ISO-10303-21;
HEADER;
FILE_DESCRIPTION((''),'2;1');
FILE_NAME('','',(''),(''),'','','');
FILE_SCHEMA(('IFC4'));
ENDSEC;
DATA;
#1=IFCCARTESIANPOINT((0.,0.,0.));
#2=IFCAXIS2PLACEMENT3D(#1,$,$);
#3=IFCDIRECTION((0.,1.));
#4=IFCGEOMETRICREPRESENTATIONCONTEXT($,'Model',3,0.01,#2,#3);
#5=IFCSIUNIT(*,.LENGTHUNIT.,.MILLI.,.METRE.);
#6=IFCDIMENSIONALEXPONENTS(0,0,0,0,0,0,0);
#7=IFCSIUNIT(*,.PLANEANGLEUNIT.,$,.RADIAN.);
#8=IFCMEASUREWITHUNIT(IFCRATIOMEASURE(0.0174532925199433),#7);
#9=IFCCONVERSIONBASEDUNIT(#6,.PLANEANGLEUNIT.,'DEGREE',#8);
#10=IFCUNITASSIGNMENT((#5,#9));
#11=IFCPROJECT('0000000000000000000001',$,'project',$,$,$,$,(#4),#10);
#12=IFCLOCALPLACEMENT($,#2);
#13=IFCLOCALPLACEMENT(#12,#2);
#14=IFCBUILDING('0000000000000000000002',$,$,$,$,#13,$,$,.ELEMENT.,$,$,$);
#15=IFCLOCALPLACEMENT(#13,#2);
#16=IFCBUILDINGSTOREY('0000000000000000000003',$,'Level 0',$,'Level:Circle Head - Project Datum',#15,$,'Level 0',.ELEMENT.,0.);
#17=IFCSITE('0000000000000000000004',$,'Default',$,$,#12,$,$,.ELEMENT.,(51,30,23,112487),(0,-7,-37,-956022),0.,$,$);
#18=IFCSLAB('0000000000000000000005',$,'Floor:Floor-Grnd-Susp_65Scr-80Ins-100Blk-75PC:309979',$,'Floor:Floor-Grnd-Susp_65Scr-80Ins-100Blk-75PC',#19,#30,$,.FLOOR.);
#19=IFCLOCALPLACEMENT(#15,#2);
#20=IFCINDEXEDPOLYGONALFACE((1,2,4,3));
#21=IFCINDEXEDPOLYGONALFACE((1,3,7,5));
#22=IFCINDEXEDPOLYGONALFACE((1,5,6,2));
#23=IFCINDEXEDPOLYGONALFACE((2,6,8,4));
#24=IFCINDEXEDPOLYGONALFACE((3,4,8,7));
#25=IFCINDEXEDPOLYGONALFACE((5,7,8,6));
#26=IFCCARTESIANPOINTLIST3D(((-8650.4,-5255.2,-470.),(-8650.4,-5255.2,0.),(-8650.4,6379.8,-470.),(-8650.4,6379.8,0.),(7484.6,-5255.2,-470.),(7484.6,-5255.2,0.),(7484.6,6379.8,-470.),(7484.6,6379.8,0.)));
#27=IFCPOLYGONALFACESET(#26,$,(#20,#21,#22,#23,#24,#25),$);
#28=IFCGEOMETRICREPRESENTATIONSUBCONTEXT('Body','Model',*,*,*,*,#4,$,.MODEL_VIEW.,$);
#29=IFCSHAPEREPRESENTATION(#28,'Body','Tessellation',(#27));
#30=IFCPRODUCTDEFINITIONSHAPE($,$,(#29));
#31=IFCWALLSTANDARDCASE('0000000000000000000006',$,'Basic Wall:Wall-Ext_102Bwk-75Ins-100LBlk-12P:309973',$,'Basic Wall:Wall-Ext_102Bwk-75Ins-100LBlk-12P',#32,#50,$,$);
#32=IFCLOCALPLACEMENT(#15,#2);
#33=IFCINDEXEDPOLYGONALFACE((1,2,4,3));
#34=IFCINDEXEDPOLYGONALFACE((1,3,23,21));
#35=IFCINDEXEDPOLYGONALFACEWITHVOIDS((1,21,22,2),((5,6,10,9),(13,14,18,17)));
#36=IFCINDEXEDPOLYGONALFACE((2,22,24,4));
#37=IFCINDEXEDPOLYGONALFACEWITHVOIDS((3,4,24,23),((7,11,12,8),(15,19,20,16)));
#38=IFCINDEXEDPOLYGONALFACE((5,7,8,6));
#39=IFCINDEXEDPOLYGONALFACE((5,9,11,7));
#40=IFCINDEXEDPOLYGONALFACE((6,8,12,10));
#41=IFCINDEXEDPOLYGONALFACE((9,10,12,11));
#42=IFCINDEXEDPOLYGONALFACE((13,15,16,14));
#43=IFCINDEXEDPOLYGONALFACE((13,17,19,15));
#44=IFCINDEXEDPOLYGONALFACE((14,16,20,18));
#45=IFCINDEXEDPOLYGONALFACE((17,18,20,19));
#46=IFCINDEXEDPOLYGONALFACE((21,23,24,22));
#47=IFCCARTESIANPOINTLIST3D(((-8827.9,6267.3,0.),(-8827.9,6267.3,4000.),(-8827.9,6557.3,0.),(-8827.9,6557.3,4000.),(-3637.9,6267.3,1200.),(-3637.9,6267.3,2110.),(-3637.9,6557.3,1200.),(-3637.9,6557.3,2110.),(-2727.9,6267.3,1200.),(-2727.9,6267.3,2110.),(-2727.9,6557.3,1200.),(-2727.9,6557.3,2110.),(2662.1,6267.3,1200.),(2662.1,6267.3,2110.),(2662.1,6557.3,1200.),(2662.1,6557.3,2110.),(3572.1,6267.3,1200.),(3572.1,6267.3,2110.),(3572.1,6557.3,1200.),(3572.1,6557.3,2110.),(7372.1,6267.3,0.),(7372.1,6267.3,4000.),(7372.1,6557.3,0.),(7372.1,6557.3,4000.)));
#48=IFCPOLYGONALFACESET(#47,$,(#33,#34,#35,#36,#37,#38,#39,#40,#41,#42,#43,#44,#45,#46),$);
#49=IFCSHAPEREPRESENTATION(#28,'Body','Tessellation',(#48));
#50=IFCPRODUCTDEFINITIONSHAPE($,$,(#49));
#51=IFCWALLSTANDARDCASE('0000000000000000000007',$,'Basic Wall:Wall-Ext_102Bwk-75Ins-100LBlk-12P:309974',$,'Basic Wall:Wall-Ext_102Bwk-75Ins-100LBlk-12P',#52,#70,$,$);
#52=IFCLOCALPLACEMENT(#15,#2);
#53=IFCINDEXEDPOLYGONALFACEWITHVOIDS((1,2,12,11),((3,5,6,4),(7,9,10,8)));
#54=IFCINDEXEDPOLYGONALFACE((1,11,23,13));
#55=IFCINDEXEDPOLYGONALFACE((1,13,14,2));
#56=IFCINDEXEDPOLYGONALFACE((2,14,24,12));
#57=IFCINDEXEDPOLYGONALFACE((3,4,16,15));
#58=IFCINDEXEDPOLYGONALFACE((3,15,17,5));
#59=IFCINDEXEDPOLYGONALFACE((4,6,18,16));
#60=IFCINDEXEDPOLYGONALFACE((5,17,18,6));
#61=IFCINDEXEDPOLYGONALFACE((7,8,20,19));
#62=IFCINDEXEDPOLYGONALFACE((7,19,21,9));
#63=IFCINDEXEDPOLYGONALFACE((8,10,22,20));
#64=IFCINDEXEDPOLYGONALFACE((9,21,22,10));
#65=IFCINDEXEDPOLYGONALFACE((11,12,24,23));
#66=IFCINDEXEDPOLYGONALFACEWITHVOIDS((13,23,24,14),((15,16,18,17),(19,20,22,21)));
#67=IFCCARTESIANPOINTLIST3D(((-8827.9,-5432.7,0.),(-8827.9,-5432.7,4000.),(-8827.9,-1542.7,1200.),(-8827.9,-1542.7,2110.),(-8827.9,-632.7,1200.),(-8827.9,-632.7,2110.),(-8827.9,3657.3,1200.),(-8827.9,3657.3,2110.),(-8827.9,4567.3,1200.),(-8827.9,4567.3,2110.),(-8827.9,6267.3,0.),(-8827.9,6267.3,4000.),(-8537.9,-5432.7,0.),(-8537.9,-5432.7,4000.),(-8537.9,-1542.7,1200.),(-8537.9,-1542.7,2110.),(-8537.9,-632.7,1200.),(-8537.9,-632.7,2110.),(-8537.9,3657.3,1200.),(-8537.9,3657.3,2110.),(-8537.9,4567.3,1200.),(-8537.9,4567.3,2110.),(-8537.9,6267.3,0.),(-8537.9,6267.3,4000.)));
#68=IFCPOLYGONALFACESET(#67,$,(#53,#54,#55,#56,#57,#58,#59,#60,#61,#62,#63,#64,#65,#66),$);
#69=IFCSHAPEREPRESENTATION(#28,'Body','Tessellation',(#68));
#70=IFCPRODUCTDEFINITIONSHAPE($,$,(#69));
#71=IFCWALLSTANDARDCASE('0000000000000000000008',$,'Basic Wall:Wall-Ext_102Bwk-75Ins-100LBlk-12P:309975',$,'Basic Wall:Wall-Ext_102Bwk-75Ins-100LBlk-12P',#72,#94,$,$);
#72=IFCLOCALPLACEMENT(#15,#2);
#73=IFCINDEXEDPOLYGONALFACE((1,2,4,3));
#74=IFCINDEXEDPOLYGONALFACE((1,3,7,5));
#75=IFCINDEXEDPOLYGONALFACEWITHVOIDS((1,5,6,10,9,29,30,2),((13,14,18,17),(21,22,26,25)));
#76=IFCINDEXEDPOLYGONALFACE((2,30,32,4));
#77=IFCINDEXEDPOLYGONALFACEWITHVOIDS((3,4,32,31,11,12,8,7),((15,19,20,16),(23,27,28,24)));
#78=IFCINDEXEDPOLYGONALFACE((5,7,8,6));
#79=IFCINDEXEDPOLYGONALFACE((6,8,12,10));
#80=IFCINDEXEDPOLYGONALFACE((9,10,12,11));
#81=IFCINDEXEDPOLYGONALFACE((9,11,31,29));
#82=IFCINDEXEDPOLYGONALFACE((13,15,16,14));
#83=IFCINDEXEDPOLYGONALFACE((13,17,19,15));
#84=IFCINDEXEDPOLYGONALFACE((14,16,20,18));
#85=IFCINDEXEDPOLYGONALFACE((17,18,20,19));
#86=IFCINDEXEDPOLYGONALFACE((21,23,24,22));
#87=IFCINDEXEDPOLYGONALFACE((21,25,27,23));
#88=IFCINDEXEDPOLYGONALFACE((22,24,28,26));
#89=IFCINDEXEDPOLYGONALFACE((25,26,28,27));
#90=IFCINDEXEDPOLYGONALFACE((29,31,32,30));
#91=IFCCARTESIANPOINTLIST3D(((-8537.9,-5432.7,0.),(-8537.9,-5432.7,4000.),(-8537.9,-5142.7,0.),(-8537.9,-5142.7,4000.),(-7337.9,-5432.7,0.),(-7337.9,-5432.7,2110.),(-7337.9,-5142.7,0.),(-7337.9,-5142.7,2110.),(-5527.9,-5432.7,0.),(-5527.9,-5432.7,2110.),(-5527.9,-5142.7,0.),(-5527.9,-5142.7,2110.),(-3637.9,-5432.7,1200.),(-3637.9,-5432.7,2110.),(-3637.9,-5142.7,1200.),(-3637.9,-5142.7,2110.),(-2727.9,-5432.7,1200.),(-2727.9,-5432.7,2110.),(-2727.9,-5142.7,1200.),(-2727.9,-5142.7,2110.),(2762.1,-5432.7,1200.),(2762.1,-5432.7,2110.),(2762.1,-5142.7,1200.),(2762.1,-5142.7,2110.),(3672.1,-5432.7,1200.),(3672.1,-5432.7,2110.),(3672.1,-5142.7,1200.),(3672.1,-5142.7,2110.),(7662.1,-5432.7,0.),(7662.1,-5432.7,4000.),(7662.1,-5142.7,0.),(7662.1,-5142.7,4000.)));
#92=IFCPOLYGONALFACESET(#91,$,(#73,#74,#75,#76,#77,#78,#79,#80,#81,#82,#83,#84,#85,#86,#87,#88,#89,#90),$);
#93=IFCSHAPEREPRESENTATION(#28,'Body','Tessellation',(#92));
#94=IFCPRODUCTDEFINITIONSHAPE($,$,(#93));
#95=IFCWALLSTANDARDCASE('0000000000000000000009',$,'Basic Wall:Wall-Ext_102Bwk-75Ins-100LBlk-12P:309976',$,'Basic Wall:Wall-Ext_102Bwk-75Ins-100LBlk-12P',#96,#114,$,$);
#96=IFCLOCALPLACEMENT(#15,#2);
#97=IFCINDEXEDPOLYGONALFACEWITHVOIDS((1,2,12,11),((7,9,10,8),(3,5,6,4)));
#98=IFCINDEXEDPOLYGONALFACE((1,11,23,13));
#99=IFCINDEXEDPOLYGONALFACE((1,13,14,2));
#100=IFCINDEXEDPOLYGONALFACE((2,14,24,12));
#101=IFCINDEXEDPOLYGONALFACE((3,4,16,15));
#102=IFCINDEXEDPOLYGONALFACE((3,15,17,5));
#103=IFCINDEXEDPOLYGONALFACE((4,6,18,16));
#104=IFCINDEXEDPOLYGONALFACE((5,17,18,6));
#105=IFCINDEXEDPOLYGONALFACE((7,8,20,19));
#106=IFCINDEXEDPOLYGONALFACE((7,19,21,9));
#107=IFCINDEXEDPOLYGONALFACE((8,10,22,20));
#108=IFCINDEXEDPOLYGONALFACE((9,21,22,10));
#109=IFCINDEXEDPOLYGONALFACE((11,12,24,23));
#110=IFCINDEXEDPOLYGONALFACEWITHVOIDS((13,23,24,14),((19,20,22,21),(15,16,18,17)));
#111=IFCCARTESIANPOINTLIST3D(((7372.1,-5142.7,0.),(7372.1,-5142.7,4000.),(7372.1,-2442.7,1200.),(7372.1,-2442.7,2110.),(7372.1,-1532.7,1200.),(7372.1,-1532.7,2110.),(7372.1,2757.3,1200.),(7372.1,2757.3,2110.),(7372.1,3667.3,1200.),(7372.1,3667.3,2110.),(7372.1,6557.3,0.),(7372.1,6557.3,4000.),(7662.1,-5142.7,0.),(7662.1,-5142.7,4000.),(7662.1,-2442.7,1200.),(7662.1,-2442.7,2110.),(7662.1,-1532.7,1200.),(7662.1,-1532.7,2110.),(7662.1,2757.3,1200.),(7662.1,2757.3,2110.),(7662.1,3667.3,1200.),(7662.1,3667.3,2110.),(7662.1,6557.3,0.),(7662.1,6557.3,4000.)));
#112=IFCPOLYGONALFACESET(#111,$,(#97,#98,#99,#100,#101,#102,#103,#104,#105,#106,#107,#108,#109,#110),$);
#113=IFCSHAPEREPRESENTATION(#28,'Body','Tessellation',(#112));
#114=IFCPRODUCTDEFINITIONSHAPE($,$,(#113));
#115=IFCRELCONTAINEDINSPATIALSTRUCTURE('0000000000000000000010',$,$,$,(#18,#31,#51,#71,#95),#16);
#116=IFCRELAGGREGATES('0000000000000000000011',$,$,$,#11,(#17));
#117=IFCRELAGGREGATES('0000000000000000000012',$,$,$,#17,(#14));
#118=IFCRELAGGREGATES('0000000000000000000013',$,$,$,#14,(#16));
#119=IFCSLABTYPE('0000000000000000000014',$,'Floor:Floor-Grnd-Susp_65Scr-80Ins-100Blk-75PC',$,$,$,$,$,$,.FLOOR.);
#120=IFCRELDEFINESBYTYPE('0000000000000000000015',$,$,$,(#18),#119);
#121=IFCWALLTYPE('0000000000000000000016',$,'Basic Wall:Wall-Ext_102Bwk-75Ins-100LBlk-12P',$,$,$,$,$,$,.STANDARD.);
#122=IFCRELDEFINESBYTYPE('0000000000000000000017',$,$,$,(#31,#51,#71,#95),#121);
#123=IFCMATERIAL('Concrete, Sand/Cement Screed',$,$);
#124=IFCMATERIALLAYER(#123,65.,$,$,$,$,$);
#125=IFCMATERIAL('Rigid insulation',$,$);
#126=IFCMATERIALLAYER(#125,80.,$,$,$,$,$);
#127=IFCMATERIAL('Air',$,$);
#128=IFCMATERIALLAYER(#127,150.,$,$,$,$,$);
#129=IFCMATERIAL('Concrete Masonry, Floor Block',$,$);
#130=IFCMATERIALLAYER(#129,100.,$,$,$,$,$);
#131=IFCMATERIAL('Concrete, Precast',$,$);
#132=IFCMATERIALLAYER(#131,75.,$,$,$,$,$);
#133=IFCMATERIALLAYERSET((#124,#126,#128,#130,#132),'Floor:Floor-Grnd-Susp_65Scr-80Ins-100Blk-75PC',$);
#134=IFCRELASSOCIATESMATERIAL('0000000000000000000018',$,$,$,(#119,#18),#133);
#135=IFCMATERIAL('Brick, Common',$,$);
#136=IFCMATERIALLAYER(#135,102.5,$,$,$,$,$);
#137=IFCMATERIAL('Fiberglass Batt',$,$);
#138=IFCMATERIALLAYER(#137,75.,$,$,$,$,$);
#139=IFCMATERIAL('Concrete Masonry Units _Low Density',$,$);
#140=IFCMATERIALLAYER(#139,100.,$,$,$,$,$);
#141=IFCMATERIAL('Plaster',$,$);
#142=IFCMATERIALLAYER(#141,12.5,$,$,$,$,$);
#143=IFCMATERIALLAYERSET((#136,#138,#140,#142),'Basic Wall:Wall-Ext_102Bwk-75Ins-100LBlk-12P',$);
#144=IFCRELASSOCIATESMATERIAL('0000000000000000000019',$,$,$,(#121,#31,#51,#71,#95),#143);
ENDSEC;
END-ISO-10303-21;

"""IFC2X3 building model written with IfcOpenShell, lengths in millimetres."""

from ifc_helpers import new_model, entity, si_unit, converted_unit, direction, frame, frame_2d, origin, place, context, subcontext, project, spatial, rectangle, extrude, material, layer, layer_set, layer_usage, type_object, element, save


model = new_model("IFC2X3")

# Units and contexts
model_context = context("Model", 3, precision=0.01, world=origin(), true_north=direction((0.0, 1.0)))
body_context = subcontext(model_context, "Body", "Model", "MODEL_VIEW")
ifc_project = project(units=[si_unit("LENGTHUNIT", "METRE", prefix="MILLI"), converted_unit("PLANEANGLEUNIT", "DEGREE", entity("IfcRatioMeasure", 0.0174532925199433), si_unit("PLANEANGLEUNIT", "RADIAN"), dimensions=[0, 0, 0, 0, 0, 0, 0])], contexts=[model_context])

# Site, building, storey
site_placement = place(None, origin())
site = spatial("IfcSite", under=ifc_project, at=site_placement, Name="Default", CompositionType="ELEMENT", RefLatitude=(51, 30, 23, 112487), RefLongitude=(0, -7, -37, -956022), RefElevation=0.0)
building_placement = place(site_placement, origin())
building = spatial("IfcBuilding", under=site, at=building_placement, CompositionType="ELEMENT")
storey_placement = place(building_placement, origin())
storey = spatial("IfcBuildingStorey", under=building, at=storey_placement, Name="Level 0", ObjectType="Level:Circle Head - Project Datum", LongName="Level 0", CompositionType="ELEMENT", Elevation=0.0)

# Slab
ifc_material_1 = material(Name="Concrete, Sand/Cement Screed")
ifc_layer_1 = layer(ifc_material_1, 65.0)
ifc_material_2 = material(Name="Rigid insulation")
ifc_layer_2 = layer(ifc_material_2, 80.0)
ifc_material_3 = material(Name="Air")
ifc_layer_3 = layer(ifc_material_3, 150.0)
ifc_material_4 = material(Name="Concrete Masonry, Floor Block")
ifc_layer_4 = layer(ifc_material_4, 100.0)
ifc_material_5 = material(Name="Concrete, Precast")
ifc_layer_5 = layer(ifc_material_5, 75.0)
ifc_layer_set_1 = layer_set([ifc_layer_1, ifc_layer_2, ifc_layer_3, ifc_layer_4, ifc_layer_5], Name="Floor:Floor-Grnd-Susp_65Scr-80Ins-100Blk-75PC")
ifc_layer_usage_1 = layer_usage(ifc_layer_set_1, "AXIS3", "POSITIVE", 0.0)
slab_type = type_object("IfcSlabType", Name="Floor:Floor-Grnd-Susp_65Scr-80Ins-100Blk-75PC", PredefinedType="FLOOR", material=ifc_layer_set_1)
slab_placement = place(storey_placement, origin())
element("IfcSlab", 1, at=slab_placement, inside=storey, type_object=slab_type, material=ifc_layer_usage_1, Name="Floor:Floor-Grnd-Susp_65Scr-80Ins-100Blk-75PC:309979", ObjectType="Floor:Floor-Grnd-Susp_65Scr-80Ins-100Blk-75PC", PredefinedType="FLOOR", context=body_context, shape_type="SweptSolid", body=[
    extrude(rectangle(XDim=11635.0, YDim=16135.0, at=frame_2d((0.0, 0.0), x_axis=(1.0, 0.0))), frame((-582.9, 562.3, 0.0), z_axis=(0.0, 0.0, -1.0), x_axis=(0.0, 1.0, 0.0)), (0.0, 0.0, 1.0), 470.0),
])

# Walls, openings
ifc_material_6 = material(Name="Brick, Common")
ifc_layer_6 = layer(ifc_material_6, 102.5)
ifc_material_7 = material(Name="Fiberglass Batt")
ifc_layer_7 = layer(ifc_material_7, 75.0)
ifc_material_8 = material(Name="Concrete Masonry Units _Low Density")
ifc_layer_8 = layer(ifc_material_8, 100.0)
ifc_material_9 = material(Name="Plaster")
ifc_layer_9 = layer(ifc_material_9, 12.5)
ifc_layer_set_2 = layer_set([ifc_layer_6, ifc_layer_7, ifc_layer_8, ifc_layer_9], Name="Basic Wall:Wall-Ext_102Bwk-75Ins-100LBlk-12P")
ifc_layer_usage_2 = layer_usage(ifc_layer_set_2, "AXIS2", "NEGATIVE", 145.0)
wall_type = type_object("IfcWallType", Name="Basic Wall:Wall-Ext_102Bwk-75Ins-100LBlk-12P", PredefinedType="STANDARD", material=ifc_layer_set_2)
wall_1_placement = place(storey_placement, frame((-8827.9, 6412.3, 0.0)))
wall_1 = element("IfcWallStandardCase", 2, at=wall_1_placement, inside=storey, type_object=wall_type, material=ifc_layer_usage_2, Name="Basic Wall:Wall-Ext_102Bwk-75Ins-100LBlk-12P:309973", ObjectType="Basic Wall:Wall-Ext_102Bwk-75Ins-100LBlk-12P", context=body_context, shape_type="SweptSolid", body=[
    extrude(rectangle(XDim=16200.0, YDim=290.0, at=frame_2d((8100.0, 0.0), x_axis=(-1.0, 0.0))), origin(), (0.0, 0.0, 1.0), 4000.0),
])
opening_1_placement = place(wall_1_placement, frame((11490.0, -145.0, 1200.0)))
element("IfcOpeningElement", 3, at=opening_1_placement, cuts=wall_1, ObjectType="Opening", context=body_context, shape_type="SweptSolid", body=[
    extrude(rectangle(XDim=910.0, YDim=910.0, at=frame_2d((455.0, 455.0), x_axis=(-1.0, 0.0))), frame((0.0, 0.0, 0.0), z_axis=(0.0, 1.0, 0.0), x_axis=(0.0, 0.0, 1.0)), (0.0, 0.0, 1.0), 290.0),
])
opening_2_placement = place(wall_1_placement, frame((5190.0, -145.0, 1200.0)))
element("IfcOpeningElement", 4, at=opening_2_placement, cuts=wall_1, ObjectType="Opening", context=body_context, shape_type="SweptSolid", body=[
    extrude(rectangle(XDim=910.0, YDim=910.0, at=frame_2d((455.0, 455.0), x_axis=(-1.0, 0.0))), frame((0.0, 0.0, 0.0), z_axis=(0.0, 1.0, 0.0), x_axis=(0.0, 0.0, 1.0)), (0.0, 0.0, 1.0), 290.0),
])
ifc_layer_usage_3 = layer_usage(ifc_layer_set_2, "AXIS2", "NEGATIVE", 145.0)
wall_2_placement = place(storey_placement, frame((-8682.9, -5432.7, 0.0), z_axis=(0.0, 0.0, 1.0), x_axis=(0.0, 1.0, 0.0)))
wall_2 = element("IfcWallStandardCase", 5, at=wall_2_placement, inside=storey, type_object=wall_type, material=ifc_layer_usage_3, Name="Basic Wall:Wall-Ext_102Bwk-75Ins-100LBlk-12P:309974", ObjectType="Basic Wall:Wall-Ext_102Bwk-75Ins-100LBlk-12P", context=body_context, shape_type="SweptSolid", body=[
    extrude(rectangle(XDim=11700.0, YDim=290.0, at=frame_2d((5850.0, 0.0), x_axis=(-1.0, 0.0))), origin(), (0.0, 0.0, 1.0), 4000.0),
])
opening_3_placement = place(wall_2_placement, frame((9090.0, -145.0, 1200.0)))
element("IfcOpeningElement", 6, at=opening_3_placement, cuts=wall_2, ObjectType="Opening", context=body_context, shape_type="SweptSolid", body=[
    extrude(rectangle(XDim=910.0, YDim=910.0, at=frame_2d((455.0, 455.0), x_axis=(-1.0, 0.0))), frame((0.0, 0.0, 0.0), z_axis=(0.0, 1.0, 0.0), x_axis=(0.0, 0.0, 1.0)), (0.0, 0.0, 1.0), 290.0),
])
opening_4_placement = place(wall_2_placement, frame((3890.0, -145.0, 1200.0)))
element("IfcOpeningElement", 7, at=opening_4_placement, cuts=wall_2, ObjectType="Opening", context=body_context, shape_type="SweptSolid", body=[
    extrude(rectangle(XDim=910.0, YDim=910.0, at=frame_2d((455.0, 455.0), x_axis=(-1.0, 0.0))), frame((0.0, 0.0, 0.0), z_axis=(0.0, 1.0, 0.0), x_axis=(0.0, 0.0, 1.0)), (0.0, 0.0, 1.0), 290.0),
])
ifc_layer_usage_4 = layer_usage(ifc_layer_set_2, "AXIS2", "NEGATIVE", 145.0)
wall_3_placement = place(storey_placement, frame((7662.1, -5287.7, 0.0), z_axis=(0.0, 0.0, 1.0), x_axis=(-1.0, 0.0, 0.0)))
wall_3 = element("IfcWallStandardCase", 8, at=wall_3_placement, inside=storey, type_object=wall_type, material=ifc_layer_usage_4, Name="Basic Wall:Wall-Ext_102Bwk-75Ins-100LBlk-12P:309975", ObjectType="Basic Wall:Wall-Ext_102Bwk-75Ins-100LBlk-12P", context=body_context, shape_type="SweptSolid", body=[
    extrude(rectangle(XDim=16200.0, YDim=290.0, at=frame_2d((8100.0, 0.0), x_axis=(-1.0, 0.0))), origin(), (0.0, 0.0, 1.0), 4000.0),
])
opening_5_placement = place(wall_3_placement, frame((13190.0, -145.0, 0.0)))
element("IfcOpeningElement", 9, at=opening_5_placement, cuts=wall_3, ObjectType="Opening", context=body_context, shape_type="SweptSolid", body=[
    extrude(rectangle(XDim=2110.0, YDim=1810.0, at=frame_2d((1055.0, 905.0), x_axis=(-1.0, 0.0))), frame((0.0, 0.0, 0.0), z_axis=(0.0, 1.0, 0.0), x_axis=(0.0, 0.0, 1.0)), (0.0, 0.0, 1.0), 290.0),
])
opening_6_placement = place(wall_3_placement, frame((10390.0, -145.0, 1200.0)))
element("IfcOpeningElement", 10, at=opening_6_placement, cuts=wall_3, ObjectType="Opening", context=body_context, shape_type="SweptSolid", body=[
    extrude(rectangle(XDim=910.0, YDim=910.0, at=frame_2d((455.0, 455.0), x_axis=(-1.0, 0.0))), frame((0.0, 0.0, 0.0), z_axis=(0.0, 1.0, 0.0), x_axis=(0.0, 0.0, 1.0)), (0.0, 0.0, 1.0), 290.0),
])
opening_7_placement = place(wall_3_placement, frame((3990.0, -145.0, 1200.0)))
element("IfcOpeningElement", 11, at=opening_7_placement, cuts=wall_3, ObjectType="Opening", context=body_context, shape_type="SweptSolid", body=[
    extrude(rectangle(XDim=910.0, YDim=910.0, at=frame_2d((455.0, 455.0), x_axis=(-1.0, 0.0))), frame((0.0, 0.0, 0.0), z_axis=(0.0, 1.0, 0.0), x_axis=(0.0, 0.0, 1.0)), (0.0, 0.0, 1.0), 290.0),
])
ifc_layer_usage_5 = layer_usage(ifc_layer_set_2, "AXIS2", "NEGATIVE", 145.0)
wall_4_placement = place(storey_placement, frame((7517.1, 6557.3, 0.0), z_axis=(0.0, 0.0, 1.0), x_axis=(0.0, -1.0, 0.0)))
wall_4 = element("IfcWallStandardCase", 12, at=wall_4_placement, inside=storey, type_object=wall_type, material=ifc_layer_usage_5, Name="Basic Wall:Wall-Ext_102Bwk-75Ins-100LBlk-12P:309976", ObjectType="Basic Wall:Wall-Ext_102Bwk-75Ins-100LBlk-12P", context=body_context, shape_type="SweptSolid", body=[
    extrude(rectangle(XDim=11700.0, YDim=290.0, at=frame_2d((5850.0, 0.0), x_axis=(-1.0, 0.0))), origin(), (0.0, 0.0, 1.0), 4000.0),
])
opening_8_placement = place(wall_4_placement, frame((8090.0, -145.0, 1200.0)))
element("IfcOpeningElement", 13, at=opening_8_placement, cuts=wall_4, ObjectType="Opening", context=body_context, shape_type="SweptSolid", body=[
    extrude(rectangle(XDim=910.0, YDim=910.0, at=frame_2d((455.0, 455.0), x_axis=(-1.0, 0.0))), frame((0.0, 0.0, 0.0), z_axis=(0.0, 1.0, 0.0), x_axis=(0.0, 0.0, 1.0)), (0.0, 0.0, 1.0), 290.0),
])
opening_9_placement = place(wall_4_placement, frame((2890.0, -145.0, 1200.0)))
element("IfcOpeningElement", 14, at=opening_9_placement, cuts=wall_4, ObjectType="Opening", context=body_context, shape_type="SweptSolid", body=[
    extrude(rectangle(XDim=910.0, YDim=910.0, at=frame_2d((455.0, 455.0), x_axis=(-1.0, 0.0))), frame((0.0, 0.0, 0.0), z_axis=(0.0, 1.0, 0.0), x_axis=(0.0, 0.0, 1.0)), (0.0, 0.0, 1.0), 290.0),
])

save(model, "model.ifc")
